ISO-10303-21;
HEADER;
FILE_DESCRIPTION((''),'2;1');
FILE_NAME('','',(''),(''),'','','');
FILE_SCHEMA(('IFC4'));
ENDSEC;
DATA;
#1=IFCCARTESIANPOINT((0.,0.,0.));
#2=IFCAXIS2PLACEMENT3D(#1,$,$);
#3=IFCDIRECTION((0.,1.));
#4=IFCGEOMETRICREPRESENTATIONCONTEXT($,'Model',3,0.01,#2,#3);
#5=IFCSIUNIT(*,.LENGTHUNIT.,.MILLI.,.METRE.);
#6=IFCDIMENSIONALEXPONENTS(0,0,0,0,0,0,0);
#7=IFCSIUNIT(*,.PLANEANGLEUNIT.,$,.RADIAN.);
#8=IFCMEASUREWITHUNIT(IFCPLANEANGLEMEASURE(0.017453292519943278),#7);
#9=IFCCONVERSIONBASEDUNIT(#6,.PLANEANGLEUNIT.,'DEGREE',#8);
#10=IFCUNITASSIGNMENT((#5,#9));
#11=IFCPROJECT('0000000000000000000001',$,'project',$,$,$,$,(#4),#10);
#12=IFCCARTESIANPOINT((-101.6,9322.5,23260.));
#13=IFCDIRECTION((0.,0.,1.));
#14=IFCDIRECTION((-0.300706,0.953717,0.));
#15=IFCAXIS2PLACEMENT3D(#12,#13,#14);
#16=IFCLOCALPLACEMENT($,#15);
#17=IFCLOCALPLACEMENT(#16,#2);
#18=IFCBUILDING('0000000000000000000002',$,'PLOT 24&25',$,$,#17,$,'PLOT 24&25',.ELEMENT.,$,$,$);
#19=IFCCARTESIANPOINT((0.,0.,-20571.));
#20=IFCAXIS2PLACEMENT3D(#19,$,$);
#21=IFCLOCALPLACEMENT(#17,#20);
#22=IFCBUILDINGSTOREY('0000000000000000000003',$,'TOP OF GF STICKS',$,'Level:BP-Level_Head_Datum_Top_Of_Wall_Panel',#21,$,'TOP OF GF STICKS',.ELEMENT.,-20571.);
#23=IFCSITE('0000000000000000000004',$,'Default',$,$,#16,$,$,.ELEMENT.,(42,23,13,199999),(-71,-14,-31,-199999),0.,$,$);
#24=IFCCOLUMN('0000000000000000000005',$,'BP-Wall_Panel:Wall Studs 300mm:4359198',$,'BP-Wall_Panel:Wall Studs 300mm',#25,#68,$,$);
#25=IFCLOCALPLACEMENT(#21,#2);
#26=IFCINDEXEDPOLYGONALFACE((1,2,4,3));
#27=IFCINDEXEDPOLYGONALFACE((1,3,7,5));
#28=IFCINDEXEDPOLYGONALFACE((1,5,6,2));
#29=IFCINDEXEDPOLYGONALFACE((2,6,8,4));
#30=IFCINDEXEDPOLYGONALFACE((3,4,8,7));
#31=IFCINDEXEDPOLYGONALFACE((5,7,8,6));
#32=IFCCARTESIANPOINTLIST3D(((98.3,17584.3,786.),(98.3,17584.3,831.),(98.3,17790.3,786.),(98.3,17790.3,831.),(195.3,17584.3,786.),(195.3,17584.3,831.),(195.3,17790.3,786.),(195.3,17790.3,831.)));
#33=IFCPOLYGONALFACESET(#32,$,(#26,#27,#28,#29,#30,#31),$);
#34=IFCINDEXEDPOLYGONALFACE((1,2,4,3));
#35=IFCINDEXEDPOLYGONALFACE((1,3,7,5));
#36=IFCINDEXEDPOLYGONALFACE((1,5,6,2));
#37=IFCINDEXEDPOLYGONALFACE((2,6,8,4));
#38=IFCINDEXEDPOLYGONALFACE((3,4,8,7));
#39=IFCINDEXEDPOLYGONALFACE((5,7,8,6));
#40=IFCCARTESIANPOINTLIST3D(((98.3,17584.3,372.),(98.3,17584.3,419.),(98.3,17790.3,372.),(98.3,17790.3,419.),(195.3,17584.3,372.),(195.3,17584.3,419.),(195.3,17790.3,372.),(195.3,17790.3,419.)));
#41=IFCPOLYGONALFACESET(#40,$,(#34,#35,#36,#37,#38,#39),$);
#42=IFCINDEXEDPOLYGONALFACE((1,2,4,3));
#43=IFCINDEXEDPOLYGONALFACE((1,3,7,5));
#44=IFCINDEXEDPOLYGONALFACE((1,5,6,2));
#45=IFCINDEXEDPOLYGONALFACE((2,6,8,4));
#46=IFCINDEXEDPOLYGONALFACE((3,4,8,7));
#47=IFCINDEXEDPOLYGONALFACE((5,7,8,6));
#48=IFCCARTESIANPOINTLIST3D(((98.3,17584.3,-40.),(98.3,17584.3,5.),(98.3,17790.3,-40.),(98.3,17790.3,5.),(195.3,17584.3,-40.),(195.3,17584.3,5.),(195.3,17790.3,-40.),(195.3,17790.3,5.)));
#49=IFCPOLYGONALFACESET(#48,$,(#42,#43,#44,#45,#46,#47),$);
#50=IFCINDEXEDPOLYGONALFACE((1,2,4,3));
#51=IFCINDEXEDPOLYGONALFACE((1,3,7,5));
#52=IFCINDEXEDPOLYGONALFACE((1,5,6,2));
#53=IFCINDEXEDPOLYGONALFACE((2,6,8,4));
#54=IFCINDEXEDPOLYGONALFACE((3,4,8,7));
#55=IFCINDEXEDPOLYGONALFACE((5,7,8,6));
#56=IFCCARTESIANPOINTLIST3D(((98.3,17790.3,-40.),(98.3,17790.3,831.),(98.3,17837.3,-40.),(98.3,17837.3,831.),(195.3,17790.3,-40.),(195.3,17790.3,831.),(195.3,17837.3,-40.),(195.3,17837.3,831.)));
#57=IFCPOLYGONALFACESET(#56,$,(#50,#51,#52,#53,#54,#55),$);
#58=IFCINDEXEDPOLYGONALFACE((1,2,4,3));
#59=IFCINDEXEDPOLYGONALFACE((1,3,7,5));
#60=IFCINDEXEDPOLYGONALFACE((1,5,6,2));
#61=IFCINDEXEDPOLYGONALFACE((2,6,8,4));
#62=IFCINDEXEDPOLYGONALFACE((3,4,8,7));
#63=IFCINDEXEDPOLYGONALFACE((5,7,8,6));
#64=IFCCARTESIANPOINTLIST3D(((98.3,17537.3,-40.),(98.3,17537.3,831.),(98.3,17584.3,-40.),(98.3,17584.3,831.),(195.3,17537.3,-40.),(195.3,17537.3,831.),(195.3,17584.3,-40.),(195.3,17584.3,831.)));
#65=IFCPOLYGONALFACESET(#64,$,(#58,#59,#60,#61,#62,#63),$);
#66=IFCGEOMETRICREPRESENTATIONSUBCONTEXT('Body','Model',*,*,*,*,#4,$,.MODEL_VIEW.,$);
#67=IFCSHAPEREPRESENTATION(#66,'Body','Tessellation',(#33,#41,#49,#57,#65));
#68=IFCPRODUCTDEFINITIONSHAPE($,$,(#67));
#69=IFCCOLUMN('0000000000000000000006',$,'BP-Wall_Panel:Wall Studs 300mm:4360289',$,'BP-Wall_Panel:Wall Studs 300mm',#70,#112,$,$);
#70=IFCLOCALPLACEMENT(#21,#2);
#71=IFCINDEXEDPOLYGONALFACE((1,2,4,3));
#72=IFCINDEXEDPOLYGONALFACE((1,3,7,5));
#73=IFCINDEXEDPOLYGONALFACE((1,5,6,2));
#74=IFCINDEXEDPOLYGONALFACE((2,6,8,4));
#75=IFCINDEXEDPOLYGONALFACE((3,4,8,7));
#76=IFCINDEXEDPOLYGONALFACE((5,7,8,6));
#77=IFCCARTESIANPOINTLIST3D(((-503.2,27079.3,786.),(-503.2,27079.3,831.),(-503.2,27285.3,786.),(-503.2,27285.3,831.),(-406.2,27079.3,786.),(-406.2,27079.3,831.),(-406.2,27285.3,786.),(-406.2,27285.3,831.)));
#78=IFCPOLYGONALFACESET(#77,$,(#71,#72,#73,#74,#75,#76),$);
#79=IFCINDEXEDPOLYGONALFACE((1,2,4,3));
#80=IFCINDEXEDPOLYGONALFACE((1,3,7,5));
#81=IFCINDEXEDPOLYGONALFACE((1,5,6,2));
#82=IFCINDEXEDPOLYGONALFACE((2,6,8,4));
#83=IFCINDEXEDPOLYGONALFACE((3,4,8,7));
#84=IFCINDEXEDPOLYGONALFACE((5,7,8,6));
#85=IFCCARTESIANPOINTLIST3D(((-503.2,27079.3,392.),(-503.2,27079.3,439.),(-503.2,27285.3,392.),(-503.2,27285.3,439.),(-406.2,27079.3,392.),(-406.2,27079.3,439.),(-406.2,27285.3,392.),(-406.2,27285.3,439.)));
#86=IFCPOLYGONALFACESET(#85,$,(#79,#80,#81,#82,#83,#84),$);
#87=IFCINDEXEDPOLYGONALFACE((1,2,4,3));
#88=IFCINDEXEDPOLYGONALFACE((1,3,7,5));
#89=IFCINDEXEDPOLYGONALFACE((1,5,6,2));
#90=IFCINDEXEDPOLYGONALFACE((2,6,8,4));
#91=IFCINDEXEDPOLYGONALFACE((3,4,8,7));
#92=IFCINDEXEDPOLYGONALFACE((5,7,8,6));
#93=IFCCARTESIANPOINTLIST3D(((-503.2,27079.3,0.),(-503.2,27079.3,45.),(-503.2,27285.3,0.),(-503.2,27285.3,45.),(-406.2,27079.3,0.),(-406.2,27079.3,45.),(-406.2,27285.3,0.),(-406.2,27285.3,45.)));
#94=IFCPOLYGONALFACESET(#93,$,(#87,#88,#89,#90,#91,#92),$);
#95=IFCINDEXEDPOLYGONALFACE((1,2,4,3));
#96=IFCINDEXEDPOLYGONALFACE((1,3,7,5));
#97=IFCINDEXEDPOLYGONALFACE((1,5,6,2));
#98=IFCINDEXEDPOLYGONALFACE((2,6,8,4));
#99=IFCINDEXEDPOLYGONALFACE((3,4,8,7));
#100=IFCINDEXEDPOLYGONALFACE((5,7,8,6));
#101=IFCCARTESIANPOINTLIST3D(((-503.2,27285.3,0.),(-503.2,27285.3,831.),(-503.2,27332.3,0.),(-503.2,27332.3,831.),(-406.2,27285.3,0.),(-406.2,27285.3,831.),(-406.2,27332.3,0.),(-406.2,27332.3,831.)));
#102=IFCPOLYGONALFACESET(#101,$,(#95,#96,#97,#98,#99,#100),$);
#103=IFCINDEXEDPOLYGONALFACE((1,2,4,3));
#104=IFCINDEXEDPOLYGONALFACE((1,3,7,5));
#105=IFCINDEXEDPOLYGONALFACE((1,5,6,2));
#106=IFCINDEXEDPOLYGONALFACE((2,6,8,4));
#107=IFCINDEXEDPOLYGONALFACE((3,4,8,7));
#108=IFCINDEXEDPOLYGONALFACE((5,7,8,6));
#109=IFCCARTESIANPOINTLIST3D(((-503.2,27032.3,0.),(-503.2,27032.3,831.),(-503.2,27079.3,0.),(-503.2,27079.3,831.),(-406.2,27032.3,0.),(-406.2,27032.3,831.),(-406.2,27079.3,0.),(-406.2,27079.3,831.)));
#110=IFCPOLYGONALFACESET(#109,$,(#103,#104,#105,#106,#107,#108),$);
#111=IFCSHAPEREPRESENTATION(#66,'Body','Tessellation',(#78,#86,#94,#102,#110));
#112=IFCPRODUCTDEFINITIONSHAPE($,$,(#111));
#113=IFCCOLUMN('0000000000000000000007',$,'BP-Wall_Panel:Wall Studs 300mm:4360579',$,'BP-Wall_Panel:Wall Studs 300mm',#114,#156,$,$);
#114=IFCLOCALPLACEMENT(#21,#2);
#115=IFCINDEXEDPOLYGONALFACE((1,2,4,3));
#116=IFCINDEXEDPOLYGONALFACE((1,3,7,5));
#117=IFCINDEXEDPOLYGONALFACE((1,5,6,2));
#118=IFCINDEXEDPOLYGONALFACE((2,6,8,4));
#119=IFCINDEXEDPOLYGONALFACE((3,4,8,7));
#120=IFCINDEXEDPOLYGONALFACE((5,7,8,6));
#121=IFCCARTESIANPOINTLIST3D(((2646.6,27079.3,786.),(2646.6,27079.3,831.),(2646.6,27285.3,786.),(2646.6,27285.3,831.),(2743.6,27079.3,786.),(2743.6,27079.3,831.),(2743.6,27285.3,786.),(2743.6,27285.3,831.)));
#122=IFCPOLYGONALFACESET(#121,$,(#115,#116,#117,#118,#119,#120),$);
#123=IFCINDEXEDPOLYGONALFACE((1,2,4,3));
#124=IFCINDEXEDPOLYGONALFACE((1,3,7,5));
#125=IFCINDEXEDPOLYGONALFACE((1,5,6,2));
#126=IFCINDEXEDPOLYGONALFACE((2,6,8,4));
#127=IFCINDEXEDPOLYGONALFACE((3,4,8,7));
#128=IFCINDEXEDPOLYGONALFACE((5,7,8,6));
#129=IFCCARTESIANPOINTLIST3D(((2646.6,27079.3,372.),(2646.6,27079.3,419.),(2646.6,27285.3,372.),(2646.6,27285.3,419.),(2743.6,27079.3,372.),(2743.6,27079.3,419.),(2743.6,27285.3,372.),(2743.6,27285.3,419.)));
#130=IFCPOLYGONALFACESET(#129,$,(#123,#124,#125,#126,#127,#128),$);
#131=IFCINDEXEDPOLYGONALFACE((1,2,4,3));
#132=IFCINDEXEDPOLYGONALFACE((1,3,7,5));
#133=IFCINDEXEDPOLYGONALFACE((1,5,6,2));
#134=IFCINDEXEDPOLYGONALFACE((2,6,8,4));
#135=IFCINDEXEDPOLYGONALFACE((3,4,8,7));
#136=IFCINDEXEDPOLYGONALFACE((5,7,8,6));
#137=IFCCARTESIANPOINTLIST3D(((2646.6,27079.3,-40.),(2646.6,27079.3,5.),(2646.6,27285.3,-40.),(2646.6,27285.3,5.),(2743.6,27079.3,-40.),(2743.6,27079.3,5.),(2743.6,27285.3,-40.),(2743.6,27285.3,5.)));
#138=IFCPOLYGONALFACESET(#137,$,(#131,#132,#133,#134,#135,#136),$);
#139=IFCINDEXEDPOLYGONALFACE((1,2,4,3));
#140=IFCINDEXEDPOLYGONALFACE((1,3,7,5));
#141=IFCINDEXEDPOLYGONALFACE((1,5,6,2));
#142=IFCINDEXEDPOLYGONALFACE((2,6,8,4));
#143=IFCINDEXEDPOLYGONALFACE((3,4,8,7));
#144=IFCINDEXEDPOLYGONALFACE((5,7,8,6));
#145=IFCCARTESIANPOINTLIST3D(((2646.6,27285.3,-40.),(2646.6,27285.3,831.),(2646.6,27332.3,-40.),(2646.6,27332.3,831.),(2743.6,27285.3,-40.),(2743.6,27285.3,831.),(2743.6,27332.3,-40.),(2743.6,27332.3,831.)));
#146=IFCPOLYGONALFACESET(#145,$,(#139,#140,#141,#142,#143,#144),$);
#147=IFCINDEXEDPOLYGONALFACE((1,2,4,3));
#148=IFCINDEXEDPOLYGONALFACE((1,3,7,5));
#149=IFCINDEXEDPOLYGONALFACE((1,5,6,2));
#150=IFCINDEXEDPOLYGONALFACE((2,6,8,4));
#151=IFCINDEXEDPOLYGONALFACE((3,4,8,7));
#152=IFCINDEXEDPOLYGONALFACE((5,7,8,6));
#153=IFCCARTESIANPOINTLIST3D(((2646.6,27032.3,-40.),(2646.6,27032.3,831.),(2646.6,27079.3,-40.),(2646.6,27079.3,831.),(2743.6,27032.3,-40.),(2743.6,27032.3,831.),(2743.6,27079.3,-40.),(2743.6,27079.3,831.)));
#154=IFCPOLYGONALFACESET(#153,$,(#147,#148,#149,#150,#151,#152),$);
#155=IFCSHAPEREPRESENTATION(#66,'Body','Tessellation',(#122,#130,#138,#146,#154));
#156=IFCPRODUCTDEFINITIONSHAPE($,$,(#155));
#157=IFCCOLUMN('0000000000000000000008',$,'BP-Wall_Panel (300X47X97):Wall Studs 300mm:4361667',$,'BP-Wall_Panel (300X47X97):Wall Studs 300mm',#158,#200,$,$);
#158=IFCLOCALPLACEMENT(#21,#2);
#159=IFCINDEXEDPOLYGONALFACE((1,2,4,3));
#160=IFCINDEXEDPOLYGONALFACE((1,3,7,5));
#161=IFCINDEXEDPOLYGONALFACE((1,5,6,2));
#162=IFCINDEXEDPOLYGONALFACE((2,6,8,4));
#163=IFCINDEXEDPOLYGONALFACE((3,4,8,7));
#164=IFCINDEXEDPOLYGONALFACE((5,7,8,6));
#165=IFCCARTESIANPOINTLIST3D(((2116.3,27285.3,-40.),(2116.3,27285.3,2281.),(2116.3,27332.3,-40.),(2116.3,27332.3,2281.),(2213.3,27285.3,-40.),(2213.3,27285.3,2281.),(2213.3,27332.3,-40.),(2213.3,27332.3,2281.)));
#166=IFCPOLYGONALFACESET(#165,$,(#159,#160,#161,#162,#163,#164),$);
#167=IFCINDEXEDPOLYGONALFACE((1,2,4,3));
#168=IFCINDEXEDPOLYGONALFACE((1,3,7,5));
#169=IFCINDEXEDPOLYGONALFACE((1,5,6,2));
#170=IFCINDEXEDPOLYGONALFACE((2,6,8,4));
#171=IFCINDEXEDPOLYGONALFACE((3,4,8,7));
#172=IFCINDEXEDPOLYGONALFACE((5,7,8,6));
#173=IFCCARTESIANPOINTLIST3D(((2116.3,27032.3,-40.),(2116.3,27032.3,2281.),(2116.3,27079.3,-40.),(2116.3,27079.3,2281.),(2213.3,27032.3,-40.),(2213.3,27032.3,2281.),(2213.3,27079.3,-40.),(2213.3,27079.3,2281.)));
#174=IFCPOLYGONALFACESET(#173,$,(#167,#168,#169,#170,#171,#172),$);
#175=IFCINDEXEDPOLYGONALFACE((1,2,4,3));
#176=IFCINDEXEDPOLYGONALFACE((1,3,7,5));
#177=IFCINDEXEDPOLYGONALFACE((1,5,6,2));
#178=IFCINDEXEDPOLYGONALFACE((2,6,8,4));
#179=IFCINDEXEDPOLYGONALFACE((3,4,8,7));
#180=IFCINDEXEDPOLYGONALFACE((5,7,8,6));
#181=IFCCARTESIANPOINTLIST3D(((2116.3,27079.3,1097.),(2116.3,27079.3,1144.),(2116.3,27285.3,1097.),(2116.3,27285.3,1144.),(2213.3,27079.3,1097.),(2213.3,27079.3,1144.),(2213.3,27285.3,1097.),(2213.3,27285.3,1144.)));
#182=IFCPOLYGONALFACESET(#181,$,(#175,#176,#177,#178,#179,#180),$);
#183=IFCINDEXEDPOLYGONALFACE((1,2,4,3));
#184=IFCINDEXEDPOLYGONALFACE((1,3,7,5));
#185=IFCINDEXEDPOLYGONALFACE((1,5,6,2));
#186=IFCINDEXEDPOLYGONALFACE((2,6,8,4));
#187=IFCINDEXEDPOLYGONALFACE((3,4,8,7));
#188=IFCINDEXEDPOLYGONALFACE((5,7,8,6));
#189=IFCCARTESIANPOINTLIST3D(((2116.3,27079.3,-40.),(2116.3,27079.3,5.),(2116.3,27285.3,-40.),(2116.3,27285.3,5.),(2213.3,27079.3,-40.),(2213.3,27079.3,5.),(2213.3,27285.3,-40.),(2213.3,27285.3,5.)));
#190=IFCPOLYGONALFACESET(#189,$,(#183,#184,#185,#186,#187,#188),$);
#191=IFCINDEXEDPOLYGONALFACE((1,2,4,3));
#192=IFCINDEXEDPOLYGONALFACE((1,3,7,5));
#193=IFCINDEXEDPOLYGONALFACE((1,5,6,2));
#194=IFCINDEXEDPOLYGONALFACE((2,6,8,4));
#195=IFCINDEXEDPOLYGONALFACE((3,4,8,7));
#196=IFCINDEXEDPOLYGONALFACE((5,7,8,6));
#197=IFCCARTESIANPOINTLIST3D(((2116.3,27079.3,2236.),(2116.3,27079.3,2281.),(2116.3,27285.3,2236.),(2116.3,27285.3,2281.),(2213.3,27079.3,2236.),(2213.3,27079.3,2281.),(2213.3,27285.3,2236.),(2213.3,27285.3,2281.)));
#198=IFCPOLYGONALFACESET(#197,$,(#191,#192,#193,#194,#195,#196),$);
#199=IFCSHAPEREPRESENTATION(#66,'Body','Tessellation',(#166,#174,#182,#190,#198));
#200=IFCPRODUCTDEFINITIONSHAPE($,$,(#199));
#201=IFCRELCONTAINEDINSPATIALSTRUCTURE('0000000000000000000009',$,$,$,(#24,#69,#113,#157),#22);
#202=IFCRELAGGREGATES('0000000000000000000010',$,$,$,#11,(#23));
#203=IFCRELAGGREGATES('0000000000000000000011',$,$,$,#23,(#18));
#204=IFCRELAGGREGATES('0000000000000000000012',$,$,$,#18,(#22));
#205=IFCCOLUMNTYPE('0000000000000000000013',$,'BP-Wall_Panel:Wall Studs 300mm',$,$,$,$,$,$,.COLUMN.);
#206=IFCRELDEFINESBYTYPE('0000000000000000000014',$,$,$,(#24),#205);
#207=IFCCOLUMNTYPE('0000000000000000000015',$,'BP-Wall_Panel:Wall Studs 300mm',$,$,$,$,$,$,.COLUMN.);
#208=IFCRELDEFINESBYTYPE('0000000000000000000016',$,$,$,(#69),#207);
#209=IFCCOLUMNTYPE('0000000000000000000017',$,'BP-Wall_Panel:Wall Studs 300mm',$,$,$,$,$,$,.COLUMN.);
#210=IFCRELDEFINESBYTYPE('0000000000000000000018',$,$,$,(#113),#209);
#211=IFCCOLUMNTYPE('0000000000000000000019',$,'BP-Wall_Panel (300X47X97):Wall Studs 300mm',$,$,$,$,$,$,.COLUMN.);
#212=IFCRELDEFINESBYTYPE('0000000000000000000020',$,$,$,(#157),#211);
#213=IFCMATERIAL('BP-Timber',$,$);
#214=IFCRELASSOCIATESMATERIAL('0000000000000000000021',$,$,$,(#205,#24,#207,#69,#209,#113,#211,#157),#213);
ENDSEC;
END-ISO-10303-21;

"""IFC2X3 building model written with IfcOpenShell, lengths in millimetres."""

from ifc_helpers import new_model, entity, si_unit, converted_unit, direction, frame, frame_2d, origin, origin_2d_with_axis, place, context, subcontext, project, spatial, rectangle, extrude, source, transform, mapped, material, type_object, type_shapes, element, save


model = new_model("IFC2X3")

# Units and contexts
model_context = context("Model", 3, precision=0.01, world=origin(), true_north=direction((0.0, 1.0)))
body_context = subcontext(model_context, "Body", "Model", "MODEL_VIEW")
ifc_project = project(units=[si_unit("LENGTHUNIT", "METRE", prefix="MILLI"), converted_unit("PLANEANGLEUNIT", "DEGREE", entity("IfcPlaneAngleMeasure", 0.017453292519943278), si_unit("PLANEANGLEUNIT", "RADIAN"), dimensions=[0, 0, 0, 0, 0, 0, 0])], contexts=[model_context])

# Site, building, storey
site_placement = place(None, frame((-101.6, 9322.5, 23260.0), z_axis=(0.0, 0.0, 1.0), x_axis=(-0.300706, 0.953717, 0.0)))
site = spatial("IfcSite", under=ifc_project, at=site_placement, Name="Default", CompositionType="ELEMENT", RefLatitude=(42, 23, 13, 199999), RefLongitude=(-71, -14, -31, -199999), RefElevation=0.0)
building_placement = place(site_placement, origin())
building = spatial("IfcBuilding", under=site, at=building_placement, Name="PLOT 24&25", LongName="PLOT 24&25", CompositionType="ELEMENT")
storey_placement = place(building_placement, frame((0.0, 0.0, -20571.0)))
storey = spatial("IfcBuildingStorey", under=building, at=storey_placement, Name="TOP OF GF STICKS", ObjectType="Level:BP-Level_Head_Datum_Top_Of_Wall_Panel", LongName="TOP OF GF STICKS", CompositionType="ELEMENT", Elevation=-20571.0)

# Columns
ifc_material_1 = material(Name="BP-Timber")
column_type_1 = type_object("IfcColumnType", Name="BP-Wall_Panel:Wall Studs 300mm", PredefinedType="COLUMN", material=ifc_material_1)
shared_shape_1 = source(origin(), body_context, "Body", "SweptSolid", [
    extrude(rectangle(XDim=206.0, YDim=97.0, at=origin_2d_with_axis()), frame((146.8, 17687.3, -19785.0), z_axis=(0.0, 0.0, 1.0), x_axis=(0.0, -1.0, 0.0)), (0.0, 0.0, 1.0), 45.0),
    extrude(rectangle(XDim=206.0, YDim=97.0, at=frame_2d((0.0, 0.0), x_axis=(1.0, 0.0))), frame((146.8, 17687.3, -20199.0), z_axis=(0.0, 0.0, 1.0), x_axis=(0.0, -1.0, 0.0)), (0.0, 0.0, 1.0), 47.0),
    extrude(rectangle(XDim=206.0, YDim=97.0, at=origin_2d_with_axis()), frame((146.8, 17687.3, -20611.0), z_axis=(0.0, 0.0, 1.0), x_axis=(0.0, -1.0, 0.0)), (0.0, 0.0, 1.0), 45.0),
    extrude(rectangle(XDim=97.0, YDim=47.0, at=frame_2d((0.0, 0.0), x_axis=(1.0, 0.0))), frame((146.8, 17813.8, -20611.0), z_axis=(0.0, 0.0, 1.0), x_axis=(-1.0, 0.0, 0.0)), (0.0, 0.0, 1.0), 871.0),
    extrude(rectangle(XDim=97.0, YDim=47.0, at=frame_2d((0.0, 0.0), x_axis=(1.0, 0.0))), frame((146.8, 17560.8, -20611.0), z_axis=(0.0, 0.0, 1.0), x_axis=(-1.0, 0.0, 0.0)), (0.0, 0.0, 1.0), 871.0),
])
type_shapes(column_type_1, [shared_shape_1])
column_1_placement = place(storey_placement, frame((0.0, 0.0, 20571.0)))
element("IfcColumn", 1, at=column_1_placement, inside=storey, type_object=column_type_1, material=ifc_material_1, Name="BP-Wall_Panel:Wall Studs 300mm:4359198", ObjectType="BP-Wall_Panel:Wall Studs 300mm", context=body_context, shape_type="MappedRepresentation", body=[
    mapped(shared_shape_1, transform((0.0, 0.0, 0.0), scale=1.0)),
])
column_type_2 = type_object("IfcColumnType", Name="BP-Wall_Panel:Wall Studs 300mm", PredefinedType="COLUMN", material=ifc_material_1)
shared_shape_2 = source(origin(), body_context, "Body", "SweptSolid", [
    extrude(rectangle(XDim=206.0, YDim=97.0, at=frame_2d((0.0, 0.0), x_axis=(1.0, 0.0))), frame((-454.7, 27182.3, -19785.0), z_axis=(0.0, 0.0, 1.0), x_axis=(0.0, -1.0, 0.0)), (0.0, 0.0, 1.0), 45.0),
    extrude(rectangle(XDim=206.0, YDim=97.0, at=frame_2d((0.0, 0.0), x_axis=(1.0, 0.0))), frame((-454.7, 27182.3, -20179.0), z_axis=(0.0, 0.0, 1.0), x_axis=(0.0, -1.0, 0.0)), (0.0, 0.0, 1.0), 47.0),
    extrude(rectangle(XDim=206.0, YDim=97.0, at=frame_2d((0.0, 0.0), x_axis=(1.0, 0.0))), frame((-454.7, 27182.3, -20571.0), z_axis=(0.0, 0.0, 1.0), x_axis=(0.0, -1.0, 0.0)), (0.0, 0.0, 1.0), 45.0),
    extrude(rectangle(XDim=97.0, YDim=47.0, at=origin_2d_with_axis()), frame((-454.7, 27308.8, -20571.0), z_axis=(0.0, 0.0, 1.0), x_axis=(-1.0, 0.0, 0.0)), (0.0, 0.0, 1.0), 831.0),
    extrude(rectangle(XDim=97.0, YDim=47.0, at=frame_2d((0.0, 0.0), x_axis=(1.0, 0.0))), frame((-454.7, 27055.8, -20571.0), z_axis=(0.0, 0.0, 1.0), x_axis=(-1.0, 0.0, 0.0)), (0.0, 0.0, 1.0), 831.0),
])
type_shapes(column_type_2, [shared_shape_2])
column_2_placement = place(storey_placement, frame((0.0, 0.0, 20571.0)))
element("IfcColumn", 2, at=column_2_placement, inside=storey, type_object=column_type_2, material=ifc_material_1, Name="BP-Wall_Panel:Wall Studs 300mm:4360289", ObjectType="BP-Wall_Panel:Wall Studs 300mm", context=body_context, shape_type="MappedRepresentation", body=[
    mapped(shared_shape_2, transform((0.0, 0.0, 0.0), scale=1.0)),
])
column_type_3 = type_object("IfcColumnType", Name="BP-Wall_Panel:Wall Studs 300mm", PredefinedType="COLUMN", material=ifc_material_1)
shared_shape_3 = source(origin(), body_context, "Body", "SweptSolid", [
    extrude(rectangle(XDim=206.0, YDim=97.0, at=frame_2d((0.0, 0.0), x_axis=(1.0, 0.0))), frame((2695.1, 27182.3, -19785.0), z_axis=(0.0, 0.0, 1.0), x_axis=(0.0, -1.0, 0.0)), (0.0, 0.0, 1.0), 45.0),
    extrude(rectangle(XDim=206.0, YDim=97.0, at=frame_2d((0.0, 0.0), x_axis=(1.0, 0.0))), frame((2695.1, 27182.3, -20199.0), z_axis=(0.0, 0.0, 1.0), x_axis=(0.0, -1.0, 0.0)), (0.0, 0.0, 1.0), 47.0),
    extrude(rectangle(XDim=206.0, YDim=97.0, at=frame_2d((0.0, 0.0), x_axis=(1.0, 0.0))), frame((2695.1, 27182.3, -20611.0), z_axis=(0.0, 0.0, 1.0), x_axis=(0.0, -1.0, 0.0)), (0.0, 0.0, 1.0), 45.0),
    extrude(rectangle(XDim=97.0, YDim=47.0, at=frame_2d((0.0, 0.0), x_axis=(1.0, 0.0))), frame((2695.1, 27308.8, -20611.0), z_axis=(0.0, 0.0, 1.0), x_axis=(-1.0, 0.0, 0.0)), (0.0, 0.0, 1.0), 871.0),
    extrude(rectangle(XDim=97.0, YDim=47.0, at=frame_2d((0.0, 0.0), x_axis=(1.0, 0.0))), frame((2695.1, 27055.8, -20611.0), z_axis=(0.0, 0.0, 1.0), x_axis=(-1.0, 0.0, 0.0)), (0.0, 0.0, 1.0), 871.0),
])
type_shapes(column_type_3, [shared_shape_3])
column_3_placement = place(storey_placement, frame((0.0, 0.0, 20571.0)))
element("IfcColumn", 3, at=column_3_placement, inside=storey, type_object=column_type_3, material=ifc_material_1, Name="BP-Wall_Panel:Wall Studs 300mm:4360579", ObjectType="BP-Wall_Panel:Wall Studs 300mm", context=body_context, shape_type="MappedRepresentation", body=[
    mapped(shared_shape_3, transform((0.0, 0.0, 0.0), scale=1.0)),
])
column_type_4 = type_object("IfcColumnType", Name="BP-Wall_Panel (300X47X97):Wall Studs 300mm", PredefinedType="COLUMN", material=ifc_material_1)
shared_shape_4 = source(origin(), body_context, "Body", "SweptSolid", [
    extrude(rectangle(XDim=97.0, YDim=47.0, at=frame_2d((0.0, 0.0), x_axis=(1.0, 0.0))), frame((2164.8, 27308.8, -20611.0), z_axis=(0.0, 0.0, 1.0), x_axis=(-1.0, 0.0, 0.0)), (0.0, 0.0, 1.0), 2321.0),
    extrude(rectangle(XDim=97.0, YDim=47.0, at=frame_2d((0.0, 0.0), x_axis=(1.0, 0.0))), frame((2164.8, 27055.8, -20611.0), z_axis=(0.0, 0.0, 1.0), x_axis=(-1.0, 0.0, 0.0)), (0.0, 0.0, 1.0), 2321.0),
    extrude(rectangle(XDim=206.0, YDim=97.0, at=frame_2d((0.0, 0.0), x_axis=(1.0, 0.0))), frame((2164.8, 27182.3, -19474.0), z_axis=(0.0, 0.0, 1.0), x_axis=(0.0, -1.0, 0.0)), (0.0, 0.0, 1.0), 47.0),
    extrude(rectangle(XDim=206.0, YDim=97.0, at=frame_2d((0.0, 0.0), x_axis=(1.0, 0.0))), frame((2164.8, 27182.3, -20611.0), z_axis=(0.0, 0.0, 1.0), x_axis=(0.0, -1.0, 0.0)), (0.0, 0.0, 1.0), 45.0),
    extrude(rectangle(XDim=206.0, YDim=97.0, at=frame_2d((0.0, 0.0), x_axis=(1.0, 0.0))), frame((2164.8, 27182.3, -18335.0), z_axis=(0.0, 0.0, 1.0), x_axis=(0.0, -1.0, 0.0)), (0.0, 0.0, 1.0), 45.0),
])
type_shapes(column_type_4, [shared_shape_4])
column_4_placement = place(storey_placement, frame((0.0, 0.0, 20571.0)))
element("IfcColumn", 4, at=column_4_placement, inside=storey, type_object=column_type_4, material=ifc_material_1, Name="BP-Wall_Panel (300X47X97):Wall Studs 300mm:4361667", ObjectType="BP-Wall_Panel (300X47X97):Wall Studs 300mm", context=body_context, shape_type="MappedRepresentation", body=[
    mapped(shared_shape_4, transform((0.0, 0.0, 0.0), scale=1.0)),
])

save(model, "model.ifc")
